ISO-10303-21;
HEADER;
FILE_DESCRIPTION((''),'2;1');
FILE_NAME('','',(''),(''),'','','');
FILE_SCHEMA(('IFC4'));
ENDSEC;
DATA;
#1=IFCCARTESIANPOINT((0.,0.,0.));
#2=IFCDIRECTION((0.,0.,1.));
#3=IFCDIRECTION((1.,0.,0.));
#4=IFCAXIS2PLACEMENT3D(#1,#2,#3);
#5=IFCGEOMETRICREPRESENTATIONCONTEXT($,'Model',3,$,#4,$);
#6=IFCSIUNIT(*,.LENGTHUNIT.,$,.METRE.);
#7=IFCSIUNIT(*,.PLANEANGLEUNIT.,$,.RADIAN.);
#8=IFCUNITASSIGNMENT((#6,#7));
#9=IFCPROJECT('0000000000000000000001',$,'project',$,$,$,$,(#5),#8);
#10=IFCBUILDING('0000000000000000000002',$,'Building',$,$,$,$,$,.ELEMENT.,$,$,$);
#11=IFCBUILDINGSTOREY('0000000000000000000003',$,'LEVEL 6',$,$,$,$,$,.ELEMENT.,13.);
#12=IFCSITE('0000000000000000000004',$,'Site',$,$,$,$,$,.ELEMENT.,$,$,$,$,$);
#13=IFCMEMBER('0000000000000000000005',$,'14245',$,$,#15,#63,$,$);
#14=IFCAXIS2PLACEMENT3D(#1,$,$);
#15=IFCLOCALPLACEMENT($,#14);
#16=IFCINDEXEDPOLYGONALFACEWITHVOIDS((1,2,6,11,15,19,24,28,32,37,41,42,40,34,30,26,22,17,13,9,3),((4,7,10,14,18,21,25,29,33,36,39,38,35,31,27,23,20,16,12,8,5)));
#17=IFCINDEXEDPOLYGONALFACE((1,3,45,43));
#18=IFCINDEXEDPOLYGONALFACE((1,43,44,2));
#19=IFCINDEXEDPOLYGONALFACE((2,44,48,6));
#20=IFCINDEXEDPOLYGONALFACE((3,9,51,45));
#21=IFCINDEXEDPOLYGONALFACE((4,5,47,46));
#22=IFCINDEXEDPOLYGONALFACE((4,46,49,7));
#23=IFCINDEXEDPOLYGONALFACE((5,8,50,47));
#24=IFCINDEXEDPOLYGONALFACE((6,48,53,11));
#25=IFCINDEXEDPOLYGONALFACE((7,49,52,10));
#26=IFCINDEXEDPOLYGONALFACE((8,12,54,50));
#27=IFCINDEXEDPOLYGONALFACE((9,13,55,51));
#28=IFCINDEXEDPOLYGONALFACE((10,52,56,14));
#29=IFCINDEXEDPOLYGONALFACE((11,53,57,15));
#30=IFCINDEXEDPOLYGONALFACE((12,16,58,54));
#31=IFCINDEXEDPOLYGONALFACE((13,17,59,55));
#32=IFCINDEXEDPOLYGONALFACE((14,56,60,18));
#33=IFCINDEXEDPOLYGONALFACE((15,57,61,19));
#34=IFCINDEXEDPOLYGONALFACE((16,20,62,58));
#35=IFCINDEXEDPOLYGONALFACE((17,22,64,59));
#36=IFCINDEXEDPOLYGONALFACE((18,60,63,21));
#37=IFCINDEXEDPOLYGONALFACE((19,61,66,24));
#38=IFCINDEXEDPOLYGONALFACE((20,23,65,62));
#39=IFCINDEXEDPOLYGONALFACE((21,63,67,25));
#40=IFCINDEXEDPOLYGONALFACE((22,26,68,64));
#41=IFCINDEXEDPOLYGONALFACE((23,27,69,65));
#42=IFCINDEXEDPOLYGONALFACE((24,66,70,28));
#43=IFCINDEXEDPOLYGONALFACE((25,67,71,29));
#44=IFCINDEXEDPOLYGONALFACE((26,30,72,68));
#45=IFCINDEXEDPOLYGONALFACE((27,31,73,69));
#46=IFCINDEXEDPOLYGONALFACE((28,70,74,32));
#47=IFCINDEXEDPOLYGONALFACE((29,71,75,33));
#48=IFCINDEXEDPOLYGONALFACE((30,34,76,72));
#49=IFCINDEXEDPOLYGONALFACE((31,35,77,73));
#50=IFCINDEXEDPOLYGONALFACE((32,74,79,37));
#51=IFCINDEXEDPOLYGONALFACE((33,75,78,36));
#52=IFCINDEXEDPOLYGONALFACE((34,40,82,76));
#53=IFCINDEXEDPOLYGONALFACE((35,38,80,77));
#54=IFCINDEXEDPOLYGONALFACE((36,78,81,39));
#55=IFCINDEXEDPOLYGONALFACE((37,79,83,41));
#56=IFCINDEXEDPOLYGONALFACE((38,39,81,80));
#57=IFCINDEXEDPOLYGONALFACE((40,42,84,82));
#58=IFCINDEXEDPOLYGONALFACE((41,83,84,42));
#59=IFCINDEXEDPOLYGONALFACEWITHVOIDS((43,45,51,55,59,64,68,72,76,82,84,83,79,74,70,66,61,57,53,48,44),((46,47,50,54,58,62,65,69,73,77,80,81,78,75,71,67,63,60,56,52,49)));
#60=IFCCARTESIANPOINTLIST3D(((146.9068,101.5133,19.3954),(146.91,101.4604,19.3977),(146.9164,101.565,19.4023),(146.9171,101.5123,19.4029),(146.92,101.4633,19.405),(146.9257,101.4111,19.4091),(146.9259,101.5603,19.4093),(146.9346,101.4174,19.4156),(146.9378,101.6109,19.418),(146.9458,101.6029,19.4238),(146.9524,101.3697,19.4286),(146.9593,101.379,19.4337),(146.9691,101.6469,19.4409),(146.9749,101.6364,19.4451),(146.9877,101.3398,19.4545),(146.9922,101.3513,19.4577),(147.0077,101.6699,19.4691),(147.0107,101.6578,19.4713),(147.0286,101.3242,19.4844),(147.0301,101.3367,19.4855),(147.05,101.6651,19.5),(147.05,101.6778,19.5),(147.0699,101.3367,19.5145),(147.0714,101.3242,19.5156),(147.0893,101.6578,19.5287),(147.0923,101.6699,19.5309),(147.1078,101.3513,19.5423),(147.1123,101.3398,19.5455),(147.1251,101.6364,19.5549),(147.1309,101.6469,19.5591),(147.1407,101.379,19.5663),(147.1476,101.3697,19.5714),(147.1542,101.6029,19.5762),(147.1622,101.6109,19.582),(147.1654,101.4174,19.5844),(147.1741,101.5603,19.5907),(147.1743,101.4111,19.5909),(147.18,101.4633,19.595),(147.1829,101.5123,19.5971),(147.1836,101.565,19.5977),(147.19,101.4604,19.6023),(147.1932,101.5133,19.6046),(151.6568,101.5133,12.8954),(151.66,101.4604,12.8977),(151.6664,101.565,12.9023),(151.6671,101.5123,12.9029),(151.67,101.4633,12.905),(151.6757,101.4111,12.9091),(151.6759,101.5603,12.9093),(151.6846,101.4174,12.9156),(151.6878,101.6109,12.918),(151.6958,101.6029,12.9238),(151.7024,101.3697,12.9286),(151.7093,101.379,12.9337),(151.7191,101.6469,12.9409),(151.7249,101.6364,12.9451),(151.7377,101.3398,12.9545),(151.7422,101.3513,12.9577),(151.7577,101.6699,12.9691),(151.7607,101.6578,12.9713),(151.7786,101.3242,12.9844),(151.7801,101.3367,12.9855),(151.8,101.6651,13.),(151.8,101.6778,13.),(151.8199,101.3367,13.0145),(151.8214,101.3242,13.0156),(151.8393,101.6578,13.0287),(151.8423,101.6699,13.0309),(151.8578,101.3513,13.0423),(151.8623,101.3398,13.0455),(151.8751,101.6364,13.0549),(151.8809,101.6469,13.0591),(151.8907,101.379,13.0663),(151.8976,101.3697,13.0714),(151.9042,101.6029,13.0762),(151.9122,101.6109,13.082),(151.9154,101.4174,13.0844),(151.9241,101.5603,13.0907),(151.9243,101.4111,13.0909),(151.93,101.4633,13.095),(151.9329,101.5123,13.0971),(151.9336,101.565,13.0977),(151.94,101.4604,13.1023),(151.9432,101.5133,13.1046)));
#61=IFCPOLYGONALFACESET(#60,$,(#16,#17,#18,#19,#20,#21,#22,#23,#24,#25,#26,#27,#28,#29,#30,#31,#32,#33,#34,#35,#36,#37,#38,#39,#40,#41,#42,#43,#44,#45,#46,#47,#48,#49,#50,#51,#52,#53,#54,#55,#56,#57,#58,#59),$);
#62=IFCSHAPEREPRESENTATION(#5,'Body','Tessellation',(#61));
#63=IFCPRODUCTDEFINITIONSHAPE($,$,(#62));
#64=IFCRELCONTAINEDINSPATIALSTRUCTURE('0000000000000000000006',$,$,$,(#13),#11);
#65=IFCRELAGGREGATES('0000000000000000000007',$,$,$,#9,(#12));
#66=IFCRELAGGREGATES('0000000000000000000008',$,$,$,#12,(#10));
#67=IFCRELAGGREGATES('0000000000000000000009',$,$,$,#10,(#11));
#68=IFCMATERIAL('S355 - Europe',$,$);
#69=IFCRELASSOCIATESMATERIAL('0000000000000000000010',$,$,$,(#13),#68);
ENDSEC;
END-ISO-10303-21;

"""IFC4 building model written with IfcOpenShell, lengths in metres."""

from ifc_helpers import new_model, si_unit, frame, origin_with_axes, origin_2d_with_axis, place, context, project, spatial, hollow_circle, extrude, material, material_profile, profile_set, profile_usage, element, save


model = new_model("IFC4")

# Units and contexts
model_context = context("Model", 3, world=origin_with_axes())
ifc_project = project(units=[si_unit("LENGTHUNIT", "METRE"), si_unit("PLANEANGLEUNIT", "RADIAN")], contexts=[model_context])

# Site, building, storey
site = spatial("IfcSite", under=ifc_project, Name="Site", CompositionType="ELEMENT")
building = spatial("IfcBuilding", under=site, Name="Building", CompositionType="ELEMENT")
storey = spatial("IfcBuildingStorey", under=building, Name="LEVEL 6", CompositionType="ELEMENT", Elevation=13.0)

# Shared definitions
ifc_material = material(Name="S355 - Europe")

# Member
ifc_material_profile_1 = material_profile(ifc_material, hollow_circle(Radius=0.1778, WallThickness=0.0127, at=origin_2d_with_axis()))
ifc_profile_set_1 = profile_set([ifc_material_profile_1])
ifc_profile_usage_1 = profile_usage(ifc_profile_set_1, cardinal=10)
member_1_placement = place(None, frame((147.05, 101.5, 19.5), z_axis=(0.590017, 0.0, -0.807391), x_axis=(0.0, 1.0, 0.0)))
element("IfcMember", 1, at=member_1_placement, inside=storey, material=ifc_profile_usage_1, Name="14245", context=model_context, shape_type="SweptSolid", body=[
    extrude(hollow_circle(Radius=0.1778, WallThickness=0.0127, at=origin_2d_with_axis()), origin_with_axes(), (0.0, 0.0, 1.0), 8.0506),
])

save(model, "model.ifc")
